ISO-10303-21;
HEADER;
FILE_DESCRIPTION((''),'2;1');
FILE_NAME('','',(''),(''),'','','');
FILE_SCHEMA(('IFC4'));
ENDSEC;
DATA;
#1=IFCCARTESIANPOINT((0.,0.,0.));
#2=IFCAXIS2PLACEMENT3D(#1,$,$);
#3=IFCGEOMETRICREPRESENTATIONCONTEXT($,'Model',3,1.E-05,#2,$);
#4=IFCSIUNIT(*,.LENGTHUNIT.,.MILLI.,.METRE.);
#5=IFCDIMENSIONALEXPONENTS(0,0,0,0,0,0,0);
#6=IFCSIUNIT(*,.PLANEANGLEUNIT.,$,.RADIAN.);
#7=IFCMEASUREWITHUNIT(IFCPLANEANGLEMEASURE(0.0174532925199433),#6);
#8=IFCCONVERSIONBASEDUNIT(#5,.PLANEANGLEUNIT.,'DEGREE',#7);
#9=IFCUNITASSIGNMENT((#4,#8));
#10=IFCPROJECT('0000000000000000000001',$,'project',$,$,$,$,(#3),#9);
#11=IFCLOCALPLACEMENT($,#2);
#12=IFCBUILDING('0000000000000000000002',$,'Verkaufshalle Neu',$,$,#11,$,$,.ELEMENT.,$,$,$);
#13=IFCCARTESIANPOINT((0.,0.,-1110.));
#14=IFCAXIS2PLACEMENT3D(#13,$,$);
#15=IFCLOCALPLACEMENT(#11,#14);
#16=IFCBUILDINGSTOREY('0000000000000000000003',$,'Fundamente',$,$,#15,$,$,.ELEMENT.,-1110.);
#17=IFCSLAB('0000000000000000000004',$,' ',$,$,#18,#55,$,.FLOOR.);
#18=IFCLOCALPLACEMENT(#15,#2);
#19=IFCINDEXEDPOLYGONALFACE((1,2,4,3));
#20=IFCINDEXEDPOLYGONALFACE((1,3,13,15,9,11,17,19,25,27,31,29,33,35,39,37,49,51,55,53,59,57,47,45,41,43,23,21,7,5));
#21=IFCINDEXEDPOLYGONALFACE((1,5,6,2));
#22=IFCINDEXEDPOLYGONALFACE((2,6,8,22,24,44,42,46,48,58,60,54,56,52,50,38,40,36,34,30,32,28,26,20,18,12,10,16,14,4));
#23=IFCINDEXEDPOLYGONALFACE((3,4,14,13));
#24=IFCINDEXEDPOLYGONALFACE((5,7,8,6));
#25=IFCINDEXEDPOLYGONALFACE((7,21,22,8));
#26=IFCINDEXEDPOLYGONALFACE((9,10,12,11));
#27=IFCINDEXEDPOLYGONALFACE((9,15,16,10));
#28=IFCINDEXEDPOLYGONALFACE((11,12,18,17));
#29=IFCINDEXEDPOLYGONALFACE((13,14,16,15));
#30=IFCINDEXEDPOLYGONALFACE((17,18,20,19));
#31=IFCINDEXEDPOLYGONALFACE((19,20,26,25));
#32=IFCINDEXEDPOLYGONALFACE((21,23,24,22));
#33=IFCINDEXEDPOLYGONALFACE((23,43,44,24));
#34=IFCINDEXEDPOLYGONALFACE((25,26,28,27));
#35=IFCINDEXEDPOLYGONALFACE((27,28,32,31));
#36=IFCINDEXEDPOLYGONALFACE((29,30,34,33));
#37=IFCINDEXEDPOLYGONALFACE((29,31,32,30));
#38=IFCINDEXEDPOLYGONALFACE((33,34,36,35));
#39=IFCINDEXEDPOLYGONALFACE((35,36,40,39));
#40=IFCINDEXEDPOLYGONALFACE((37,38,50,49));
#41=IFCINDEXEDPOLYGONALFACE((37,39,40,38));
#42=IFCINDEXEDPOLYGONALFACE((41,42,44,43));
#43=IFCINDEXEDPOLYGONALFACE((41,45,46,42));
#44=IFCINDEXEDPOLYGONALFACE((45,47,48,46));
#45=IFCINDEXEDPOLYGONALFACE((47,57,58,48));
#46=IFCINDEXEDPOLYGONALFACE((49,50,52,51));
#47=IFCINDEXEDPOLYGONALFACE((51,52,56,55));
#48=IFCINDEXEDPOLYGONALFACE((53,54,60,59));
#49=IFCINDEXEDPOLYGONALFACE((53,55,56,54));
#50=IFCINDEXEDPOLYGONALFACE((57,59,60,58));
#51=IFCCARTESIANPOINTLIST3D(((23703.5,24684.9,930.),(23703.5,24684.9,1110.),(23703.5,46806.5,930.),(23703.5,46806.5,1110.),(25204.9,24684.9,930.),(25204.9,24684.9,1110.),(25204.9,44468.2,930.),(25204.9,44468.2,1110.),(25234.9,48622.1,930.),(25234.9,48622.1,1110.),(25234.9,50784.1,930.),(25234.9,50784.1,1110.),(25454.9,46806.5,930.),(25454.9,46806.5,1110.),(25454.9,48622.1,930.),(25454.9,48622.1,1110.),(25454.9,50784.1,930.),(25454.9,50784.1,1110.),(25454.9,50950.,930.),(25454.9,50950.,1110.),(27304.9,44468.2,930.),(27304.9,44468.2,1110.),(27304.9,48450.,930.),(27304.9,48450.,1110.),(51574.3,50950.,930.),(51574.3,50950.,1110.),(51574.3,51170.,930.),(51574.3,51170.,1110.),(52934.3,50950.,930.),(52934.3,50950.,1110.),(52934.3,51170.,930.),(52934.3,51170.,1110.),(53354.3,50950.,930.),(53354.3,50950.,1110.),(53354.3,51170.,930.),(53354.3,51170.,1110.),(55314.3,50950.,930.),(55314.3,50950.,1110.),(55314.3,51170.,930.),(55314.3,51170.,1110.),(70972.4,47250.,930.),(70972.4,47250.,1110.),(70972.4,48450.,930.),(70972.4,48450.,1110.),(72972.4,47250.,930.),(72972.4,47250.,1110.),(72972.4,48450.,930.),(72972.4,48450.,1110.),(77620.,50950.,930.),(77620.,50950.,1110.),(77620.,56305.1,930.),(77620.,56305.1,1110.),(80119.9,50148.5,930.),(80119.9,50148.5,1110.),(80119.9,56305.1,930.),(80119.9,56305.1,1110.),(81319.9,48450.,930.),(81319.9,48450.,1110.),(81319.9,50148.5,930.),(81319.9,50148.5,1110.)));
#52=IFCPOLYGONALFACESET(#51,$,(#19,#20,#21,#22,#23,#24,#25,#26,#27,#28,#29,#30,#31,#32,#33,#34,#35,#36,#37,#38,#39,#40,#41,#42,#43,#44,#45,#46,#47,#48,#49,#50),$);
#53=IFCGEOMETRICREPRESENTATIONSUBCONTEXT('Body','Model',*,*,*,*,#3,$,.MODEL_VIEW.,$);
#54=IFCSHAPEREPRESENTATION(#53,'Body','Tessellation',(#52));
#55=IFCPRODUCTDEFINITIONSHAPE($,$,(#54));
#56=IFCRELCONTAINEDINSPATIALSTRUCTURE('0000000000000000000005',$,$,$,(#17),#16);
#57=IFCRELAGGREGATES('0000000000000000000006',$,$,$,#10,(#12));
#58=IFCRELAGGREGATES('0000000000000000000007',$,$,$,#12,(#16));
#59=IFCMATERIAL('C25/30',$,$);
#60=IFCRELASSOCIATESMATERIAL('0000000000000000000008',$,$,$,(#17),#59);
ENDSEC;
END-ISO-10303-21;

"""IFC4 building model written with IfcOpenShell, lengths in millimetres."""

from ifc_helpers import new_model, entity, si_unit, converted_unit, frame, origin, origin_with_axes, place, context, subcontext, project, spatial, polyline, outline, extrude, material, element, save


model = new_model("IFC4")

# Units and contexts
model_context = context("Model", 3, precision=1e-05, world=origin())
body_context = subcontext(model_context, "Body", "Model", "MODEL_VIEW")
ifc_project = project(units=[si_unit("LENGTHUNIT", "METRE", prefix="MILLI"), converted_unit("PLANEANGLEUNIT", "DEGREE", entity("IfcPlaneAngleMeasure", 0.0174532925199433), si_unit("PLANEANGLEUNIT", "RADIAN"), dimensions=[0, 0, 0, 0, 0, 0, 0])], contexts=[model_context])

# Building, storey
building_placement = place(None, origin())
building = spatial("IfcBuilding", under=ifc_project, at=building_placement, Name="Verkaufshalle Neu", CompositionType="ELEMENT")
storey_placement = place(building_placement, frame((0.0, 0.0, -1110.0)))
storey = spatial("IfcBuildingStorey", under=building, at=storey_placement, Name="Fundamente", CompositionType="ELEMENT", Elevation=-1110.0)

# Slab
ifc_material_1 = material(Name="C25/30")
slab_1_placement = place(storey_placement, frame((23703.5, 24684.9, 930.0)))
element("IfcSlab", 1, at=slab_1_placement, inside=storey, material=ifc_material_1, Name=" ", PredefinedType="FLOOR", context=body_context, shape_type="SweptSolid", body=[
    extrude(outline(polyline([(0.0, 0.0), (1501.4, 0.0), (1501.4, 19783.4), (3601.4, 19783.4), (3601.4, 23765.1), (47268.9, 23765.1), (47268.9, 22565.2), (49268.9, 22565.2), (49268.9, 23765.1), (57616.4, 23765.1), (57616.4, 25463.6), (56416.4, 25463.6), (56416.4, 31620.3), (53916.4, 31620.3), (53916.4, 26265.1), (31610.7, 26265.1), (31610.7, 26485.1), (29650.7, 26485.1), (29650.7, 26265.1), (29230.7, 26265.1), (29230.7, 26485.1), (27870.7, 26485.1), (27870.7, 26265.1), (1751.4, 26265.1), (1751.4, 26099.2), (1531.4, 26099.2), (1531.4, 23937.2), (1751.4, 23937.2), (1751.4, 22121.6), (0.0, 22121.6), (0.0, 0.0)])), origin_with_axes(), (0.0, 0.0, 1.0), 180.0),
])

save(model, "model.ifc")
